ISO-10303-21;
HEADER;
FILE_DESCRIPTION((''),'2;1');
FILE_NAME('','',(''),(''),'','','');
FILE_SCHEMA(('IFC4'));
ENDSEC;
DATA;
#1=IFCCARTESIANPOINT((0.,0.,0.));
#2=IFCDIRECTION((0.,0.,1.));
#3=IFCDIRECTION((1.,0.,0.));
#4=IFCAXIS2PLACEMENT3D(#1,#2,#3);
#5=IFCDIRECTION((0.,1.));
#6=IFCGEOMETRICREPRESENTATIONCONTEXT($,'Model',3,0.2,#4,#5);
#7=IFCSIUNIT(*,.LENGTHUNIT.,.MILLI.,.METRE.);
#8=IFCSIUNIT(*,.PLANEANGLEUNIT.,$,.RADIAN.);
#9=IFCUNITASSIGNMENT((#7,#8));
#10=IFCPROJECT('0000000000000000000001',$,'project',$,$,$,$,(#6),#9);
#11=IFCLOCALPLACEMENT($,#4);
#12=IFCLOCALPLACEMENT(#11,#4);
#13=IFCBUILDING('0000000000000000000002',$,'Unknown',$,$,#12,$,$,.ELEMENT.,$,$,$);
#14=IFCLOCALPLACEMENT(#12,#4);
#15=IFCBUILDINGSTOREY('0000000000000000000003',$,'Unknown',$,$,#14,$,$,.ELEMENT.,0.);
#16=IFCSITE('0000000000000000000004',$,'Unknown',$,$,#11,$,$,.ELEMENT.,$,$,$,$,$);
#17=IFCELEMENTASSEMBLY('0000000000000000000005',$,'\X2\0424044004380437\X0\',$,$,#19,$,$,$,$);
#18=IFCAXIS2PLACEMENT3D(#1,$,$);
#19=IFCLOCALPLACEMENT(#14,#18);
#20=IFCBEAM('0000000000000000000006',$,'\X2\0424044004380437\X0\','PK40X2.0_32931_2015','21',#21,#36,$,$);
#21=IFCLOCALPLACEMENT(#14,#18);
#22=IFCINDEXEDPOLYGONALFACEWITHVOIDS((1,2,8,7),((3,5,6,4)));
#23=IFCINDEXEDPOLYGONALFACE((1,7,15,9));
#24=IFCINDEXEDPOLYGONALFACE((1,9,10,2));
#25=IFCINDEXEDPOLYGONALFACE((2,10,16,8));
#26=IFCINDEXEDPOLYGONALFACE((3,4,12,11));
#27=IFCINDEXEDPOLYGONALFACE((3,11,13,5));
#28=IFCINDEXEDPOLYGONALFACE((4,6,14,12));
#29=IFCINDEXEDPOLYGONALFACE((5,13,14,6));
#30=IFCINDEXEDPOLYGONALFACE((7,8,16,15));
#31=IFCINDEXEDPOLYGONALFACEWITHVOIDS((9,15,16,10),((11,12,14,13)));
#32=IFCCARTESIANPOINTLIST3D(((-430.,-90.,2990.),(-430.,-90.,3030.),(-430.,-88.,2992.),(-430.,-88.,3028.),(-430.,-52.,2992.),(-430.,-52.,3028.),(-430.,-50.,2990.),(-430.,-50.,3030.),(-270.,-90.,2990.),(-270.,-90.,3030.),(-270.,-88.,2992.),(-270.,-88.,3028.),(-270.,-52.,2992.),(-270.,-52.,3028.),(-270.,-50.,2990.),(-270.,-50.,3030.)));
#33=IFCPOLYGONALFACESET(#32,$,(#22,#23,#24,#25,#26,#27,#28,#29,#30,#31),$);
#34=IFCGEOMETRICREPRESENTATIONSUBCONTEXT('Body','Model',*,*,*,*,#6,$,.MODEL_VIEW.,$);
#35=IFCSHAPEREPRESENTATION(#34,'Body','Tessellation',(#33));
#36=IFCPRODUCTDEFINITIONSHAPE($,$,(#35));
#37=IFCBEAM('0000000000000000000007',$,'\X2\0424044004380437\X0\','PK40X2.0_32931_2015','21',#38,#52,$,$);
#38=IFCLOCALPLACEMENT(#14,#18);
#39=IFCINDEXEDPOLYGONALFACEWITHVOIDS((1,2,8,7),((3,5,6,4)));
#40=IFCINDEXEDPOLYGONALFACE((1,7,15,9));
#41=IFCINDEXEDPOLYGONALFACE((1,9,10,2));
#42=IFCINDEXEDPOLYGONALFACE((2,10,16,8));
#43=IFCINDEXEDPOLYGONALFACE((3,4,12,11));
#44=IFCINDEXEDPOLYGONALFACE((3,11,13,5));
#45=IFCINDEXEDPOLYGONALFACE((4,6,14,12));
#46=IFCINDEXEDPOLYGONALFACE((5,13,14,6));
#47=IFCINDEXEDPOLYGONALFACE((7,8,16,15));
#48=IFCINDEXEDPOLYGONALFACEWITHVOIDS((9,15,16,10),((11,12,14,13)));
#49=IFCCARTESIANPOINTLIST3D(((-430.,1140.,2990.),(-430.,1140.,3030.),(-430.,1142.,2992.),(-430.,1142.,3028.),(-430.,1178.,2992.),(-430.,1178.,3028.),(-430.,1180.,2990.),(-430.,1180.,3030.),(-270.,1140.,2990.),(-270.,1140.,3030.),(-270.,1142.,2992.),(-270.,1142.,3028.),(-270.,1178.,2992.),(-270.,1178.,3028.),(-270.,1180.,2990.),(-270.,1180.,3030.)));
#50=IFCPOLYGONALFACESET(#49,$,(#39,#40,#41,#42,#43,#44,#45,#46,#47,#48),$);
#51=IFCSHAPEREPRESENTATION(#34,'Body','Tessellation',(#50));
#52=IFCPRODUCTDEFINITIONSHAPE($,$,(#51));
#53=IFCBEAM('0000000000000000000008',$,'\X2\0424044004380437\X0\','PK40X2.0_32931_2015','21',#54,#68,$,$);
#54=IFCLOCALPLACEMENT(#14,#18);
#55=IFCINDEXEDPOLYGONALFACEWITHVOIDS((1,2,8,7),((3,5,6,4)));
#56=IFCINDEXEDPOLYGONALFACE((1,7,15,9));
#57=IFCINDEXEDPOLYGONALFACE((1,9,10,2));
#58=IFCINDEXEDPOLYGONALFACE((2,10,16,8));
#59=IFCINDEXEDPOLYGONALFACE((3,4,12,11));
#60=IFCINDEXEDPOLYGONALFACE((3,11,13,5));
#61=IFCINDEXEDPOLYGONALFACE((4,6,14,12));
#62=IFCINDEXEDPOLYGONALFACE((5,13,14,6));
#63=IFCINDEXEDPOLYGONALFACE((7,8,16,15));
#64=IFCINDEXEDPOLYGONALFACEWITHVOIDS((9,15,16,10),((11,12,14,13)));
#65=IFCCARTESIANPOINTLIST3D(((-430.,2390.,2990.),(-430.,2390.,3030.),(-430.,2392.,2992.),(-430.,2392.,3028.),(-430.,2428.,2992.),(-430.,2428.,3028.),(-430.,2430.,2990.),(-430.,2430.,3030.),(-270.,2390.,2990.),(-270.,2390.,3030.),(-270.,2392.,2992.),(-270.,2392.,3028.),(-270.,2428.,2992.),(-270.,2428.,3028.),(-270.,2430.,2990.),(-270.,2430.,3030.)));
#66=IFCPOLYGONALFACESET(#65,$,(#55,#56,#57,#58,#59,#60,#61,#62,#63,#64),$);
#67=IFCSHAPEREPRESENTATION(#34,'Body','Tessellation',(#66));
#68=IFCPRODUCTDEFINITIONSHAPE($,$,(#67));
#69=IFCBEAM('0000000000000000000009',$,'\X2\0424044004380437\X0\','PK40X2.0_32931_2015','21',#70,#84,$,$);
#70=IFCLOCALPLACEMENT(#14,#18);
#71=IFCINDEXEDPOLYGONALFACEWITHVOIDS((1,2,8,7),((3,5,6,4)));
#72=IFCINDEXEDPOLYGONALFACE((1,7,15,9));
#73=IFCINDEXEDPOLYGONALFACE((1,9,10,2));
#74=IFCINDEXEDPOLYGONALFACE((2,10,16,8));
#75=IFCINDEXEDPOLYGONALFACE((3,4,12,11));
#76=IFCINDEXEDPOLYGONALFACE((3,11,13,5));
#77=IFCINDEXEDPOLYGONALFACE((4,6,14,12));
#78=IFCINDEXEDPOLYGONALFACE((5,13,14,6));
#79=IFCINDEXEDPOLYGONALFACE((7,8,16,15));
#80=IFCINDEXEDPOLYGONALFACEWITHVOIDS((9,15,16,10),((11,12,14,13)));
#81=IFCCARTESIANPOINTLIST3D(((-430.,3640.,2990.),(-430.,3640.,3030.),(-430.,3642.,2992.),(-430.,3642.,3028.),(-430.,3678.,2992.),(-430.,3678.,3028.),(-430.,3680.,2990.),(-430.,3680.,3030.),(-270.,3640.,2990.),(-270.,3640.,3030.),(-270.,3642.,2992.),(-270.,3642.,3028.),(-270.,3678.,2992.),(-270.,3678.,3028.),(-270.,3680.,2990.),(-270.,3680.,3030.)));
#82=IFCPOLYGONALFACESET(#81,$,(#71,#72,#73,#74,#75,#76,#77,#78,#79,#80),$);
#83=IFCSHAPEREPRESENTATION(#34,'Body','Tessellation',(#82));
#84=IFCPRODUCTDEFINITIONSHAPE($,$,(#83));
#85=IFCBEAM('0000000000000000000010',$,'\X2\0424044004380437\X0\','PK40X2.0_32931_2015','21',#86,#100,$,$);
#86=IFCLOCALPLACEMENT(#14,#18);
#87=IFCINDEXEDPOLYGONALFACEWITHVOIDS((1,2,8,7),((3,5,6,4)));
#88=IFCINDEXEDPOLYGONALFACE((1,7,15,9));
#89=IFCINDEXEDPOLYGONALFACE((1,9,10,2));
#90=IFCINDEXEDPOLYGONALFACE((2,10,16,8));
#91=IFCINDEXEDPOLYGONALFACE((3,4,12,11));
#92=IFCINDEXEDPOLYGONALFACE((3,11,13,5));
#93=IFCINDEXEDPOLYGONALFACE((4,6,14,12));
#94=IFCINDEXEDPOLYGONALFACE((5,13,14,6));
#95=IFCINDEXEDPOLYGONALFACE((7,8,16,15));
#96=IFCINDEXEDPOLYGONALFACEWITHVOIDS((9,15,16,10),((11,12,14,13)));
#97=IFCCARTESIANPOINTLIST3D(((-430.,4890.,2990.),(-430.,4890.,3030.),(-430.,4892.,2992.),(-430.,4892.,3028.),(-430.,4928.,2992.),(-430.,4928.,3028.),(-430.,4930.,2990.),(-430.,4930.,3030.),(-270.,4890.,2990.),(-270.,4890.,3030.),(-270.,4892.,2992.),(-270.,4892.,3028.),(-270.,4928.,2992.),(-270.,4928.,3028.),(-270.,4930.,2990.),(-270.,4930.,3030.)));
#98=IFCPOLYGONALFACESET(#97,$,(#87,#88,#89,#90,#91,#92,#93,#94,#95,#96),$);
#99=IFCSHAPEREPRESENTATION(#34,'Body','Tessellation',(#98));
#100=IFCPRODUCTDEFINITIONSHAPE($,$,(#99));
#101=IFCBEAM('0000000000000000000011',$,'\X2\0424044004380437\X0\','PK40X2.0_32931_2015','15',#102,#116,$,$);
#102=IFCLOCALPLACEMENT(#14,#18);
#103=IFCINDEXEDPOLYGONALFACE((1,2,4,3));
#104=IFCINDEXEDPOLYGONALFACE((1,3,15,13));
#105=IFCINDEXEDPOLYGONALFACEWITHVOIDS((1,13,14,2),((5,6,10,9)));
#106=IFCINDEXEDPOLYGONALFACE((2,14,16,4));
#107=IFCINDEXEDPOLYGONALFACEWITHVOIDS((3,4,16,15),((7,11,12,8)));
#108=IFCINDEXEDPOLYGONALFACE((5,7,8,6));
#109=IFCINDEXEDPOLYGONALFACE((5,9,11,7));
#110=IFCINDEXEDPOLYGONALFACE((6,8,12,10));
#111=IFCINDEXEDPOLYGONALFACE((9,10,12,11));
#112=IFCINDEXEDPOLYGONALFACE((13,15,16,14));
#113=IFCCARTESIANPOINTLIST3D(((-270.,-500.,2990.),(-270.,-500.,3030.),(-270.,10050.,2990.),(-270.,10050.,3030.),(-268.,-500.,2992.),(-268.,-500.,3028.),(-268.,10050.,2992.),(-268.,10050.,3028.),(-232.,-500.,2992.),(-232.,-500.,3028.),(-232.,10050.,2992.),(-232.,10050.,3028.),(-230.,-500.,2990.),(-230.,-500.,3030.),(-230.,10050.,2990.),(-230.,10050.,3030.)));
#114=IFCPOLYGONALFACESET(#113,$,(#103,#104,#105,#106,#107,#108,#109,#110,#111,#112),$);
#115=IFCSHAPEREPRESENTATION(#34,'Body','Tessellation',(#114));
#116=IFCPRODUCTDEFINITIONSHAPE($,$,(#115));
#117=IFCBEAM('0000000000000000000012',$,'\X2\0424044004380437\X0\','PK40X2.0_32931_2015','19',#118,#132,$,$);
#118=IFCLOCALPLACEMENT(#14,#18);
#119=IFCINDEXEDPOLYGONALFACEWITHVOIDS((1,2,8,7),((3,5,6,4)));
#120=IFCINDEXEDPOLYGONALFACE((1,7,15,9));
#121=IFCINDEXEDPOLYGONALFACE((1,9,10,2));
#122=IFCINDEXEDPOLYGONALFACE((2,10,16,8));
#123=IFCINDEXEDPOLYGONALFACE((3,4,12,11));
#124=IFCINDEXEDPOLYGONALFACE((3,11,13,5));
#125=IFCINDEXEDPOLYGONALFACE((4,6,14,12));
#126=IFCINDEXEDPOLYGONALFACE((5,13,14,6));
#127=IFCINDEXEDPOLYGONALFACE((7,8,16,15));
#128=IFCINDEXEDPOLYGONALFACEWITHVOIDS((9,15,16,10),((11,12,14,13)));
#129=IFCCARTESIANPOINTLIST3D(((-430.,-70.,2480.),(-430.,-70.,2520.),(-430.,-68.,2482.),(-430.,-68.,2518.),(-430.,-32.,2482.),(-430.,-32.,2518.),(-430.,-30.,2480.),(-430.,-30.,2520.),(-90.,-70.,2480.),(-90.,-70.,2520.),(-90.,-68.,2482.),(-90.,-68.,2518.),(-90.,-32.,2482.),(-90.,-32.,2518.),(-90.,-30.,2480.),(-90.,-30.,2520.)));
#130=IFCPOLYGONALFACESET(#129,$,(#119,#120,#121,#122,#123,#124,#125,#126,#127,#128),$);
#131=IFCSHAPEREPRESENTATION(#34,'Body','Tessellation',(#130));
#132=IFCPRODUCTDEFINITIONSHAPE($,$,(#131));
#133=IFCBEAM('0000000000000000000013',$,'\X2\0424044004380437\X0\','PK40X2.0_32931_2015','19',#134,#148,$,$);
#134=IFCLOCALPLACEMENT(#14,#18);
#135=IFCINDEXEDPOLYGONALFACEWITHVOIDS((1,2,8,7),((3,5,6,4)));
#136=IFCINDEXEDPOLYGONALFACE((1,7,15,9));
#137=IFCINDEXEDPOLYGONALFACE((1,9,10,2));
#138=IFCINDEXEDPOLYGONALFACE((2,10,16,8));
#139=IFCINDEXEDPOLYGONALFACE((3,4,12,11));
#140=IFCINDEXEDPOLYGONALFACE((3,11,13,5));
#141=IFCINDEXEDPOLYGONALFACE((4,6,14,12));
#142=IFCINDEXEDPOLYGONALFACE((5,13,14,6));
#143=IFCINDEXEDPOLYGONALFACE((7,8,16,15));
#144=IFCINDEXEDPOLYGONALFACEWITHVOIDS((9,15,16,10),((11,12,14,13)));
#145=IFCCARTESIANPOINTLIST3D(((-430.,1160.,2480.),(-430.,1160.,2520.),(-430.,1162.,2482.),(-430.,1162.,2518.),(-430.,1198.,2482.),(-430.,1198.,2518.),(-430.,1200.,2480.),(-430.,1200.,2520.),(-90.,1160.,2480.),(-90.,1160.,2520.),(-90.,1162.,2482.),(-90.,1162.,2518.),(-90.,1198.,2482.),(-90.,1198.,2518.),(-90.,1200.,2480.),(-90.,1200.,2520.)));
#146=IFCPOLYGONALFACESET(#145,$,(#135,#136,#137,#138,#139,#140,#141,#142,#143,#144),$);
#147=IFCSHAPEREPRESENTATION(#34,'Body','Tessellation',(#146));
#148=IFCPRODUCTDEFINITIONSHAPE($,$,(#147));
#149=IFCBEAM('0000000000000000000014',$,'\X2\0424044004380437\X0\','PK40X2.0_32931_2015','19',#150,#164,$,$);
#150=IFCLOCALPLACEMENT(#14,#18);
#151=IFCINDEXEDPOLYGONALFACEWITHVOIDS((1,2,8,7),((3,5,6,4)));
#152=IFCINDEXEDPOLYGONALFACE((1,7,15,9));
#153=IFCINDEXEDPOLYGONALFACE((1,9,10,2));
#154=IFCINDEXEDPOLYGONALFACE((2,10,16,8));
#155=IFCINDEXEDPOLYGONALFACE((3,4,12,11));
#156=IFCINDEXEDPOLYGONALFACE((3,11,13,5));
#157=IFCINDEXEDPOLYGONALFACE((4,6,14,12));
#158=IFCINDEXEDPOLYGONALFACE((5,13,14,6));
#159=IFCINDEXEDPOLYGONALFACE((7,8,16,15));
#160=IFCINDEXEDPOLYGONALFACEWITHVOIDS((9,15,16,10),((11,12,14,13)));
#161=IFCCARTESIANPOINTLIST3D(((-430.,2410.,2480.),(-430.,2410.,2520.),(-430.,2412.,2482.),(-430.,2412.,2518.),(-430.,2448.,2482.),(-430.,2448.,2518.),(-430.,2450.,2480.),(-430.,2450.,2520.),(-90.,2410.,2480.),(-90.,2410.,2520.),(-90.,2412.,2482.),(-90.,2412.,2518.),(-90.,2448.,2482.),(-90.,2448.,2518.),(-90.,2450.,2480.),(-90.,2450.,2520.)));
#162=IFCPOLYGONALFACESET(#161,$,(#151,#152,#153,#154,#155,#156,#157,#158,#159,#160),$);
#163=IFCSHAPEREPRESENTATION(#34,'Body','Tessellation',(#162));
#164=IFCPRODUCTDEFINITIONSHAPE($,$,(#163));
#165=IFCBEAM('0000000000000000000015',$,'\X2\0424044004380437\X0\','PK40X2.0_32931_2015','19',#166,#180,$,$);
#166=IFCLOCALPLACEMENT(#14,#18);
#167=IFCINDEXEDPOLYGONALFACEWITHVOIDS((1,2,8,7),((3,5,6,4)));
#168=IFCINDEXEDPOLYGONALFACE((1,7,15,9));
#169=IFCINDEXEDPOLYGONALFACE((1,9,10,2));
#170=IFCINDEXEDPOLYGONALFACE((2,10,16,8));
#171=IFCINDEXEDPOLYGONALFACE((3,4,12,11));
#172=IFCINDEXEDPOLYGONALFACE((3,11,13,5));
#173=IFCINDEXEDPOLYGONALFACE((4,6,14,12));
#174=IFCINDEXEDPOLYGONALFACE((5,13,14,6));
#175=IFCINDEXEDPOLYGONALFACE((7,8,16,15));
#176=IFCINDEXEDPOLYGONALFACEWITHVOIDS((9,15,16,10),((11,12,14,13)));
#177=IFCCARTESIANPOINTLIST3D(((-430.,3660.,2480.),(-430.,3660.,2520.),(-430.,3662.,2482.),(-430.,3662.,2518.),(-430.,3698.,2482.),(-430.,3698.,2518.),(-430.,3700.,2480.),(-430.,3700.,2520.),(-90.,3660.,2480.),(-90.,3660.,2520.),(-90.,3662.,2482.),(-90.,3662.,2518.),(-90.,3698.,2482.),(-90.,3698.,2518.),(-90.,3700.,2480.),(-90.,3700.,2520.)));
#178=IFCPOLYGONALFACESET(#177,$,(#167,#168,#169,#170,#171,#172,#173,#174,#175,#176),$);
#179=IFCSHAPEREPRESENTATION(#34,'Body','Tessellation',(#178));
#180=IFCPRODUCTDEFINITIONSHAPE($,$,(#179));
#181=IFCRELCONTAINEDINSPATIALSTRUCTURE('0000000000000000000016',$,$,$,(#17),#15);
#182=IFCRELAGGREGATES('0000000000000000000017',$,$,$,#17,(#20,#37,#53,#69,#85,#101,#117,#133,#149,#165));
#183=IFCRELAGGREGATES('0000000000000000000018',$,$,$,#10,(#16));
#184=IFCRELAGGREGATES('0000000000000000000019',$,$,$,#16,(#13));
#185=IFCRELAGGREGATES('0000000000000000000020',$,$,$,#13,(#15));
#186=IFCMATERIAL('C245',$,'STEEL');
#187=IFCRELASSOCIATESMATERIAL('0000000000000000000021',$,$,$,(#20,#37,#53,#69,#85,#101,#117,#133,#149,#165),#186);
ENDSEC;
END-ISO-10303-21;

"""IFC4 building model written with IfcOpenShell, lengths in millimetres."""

from ifc_helpers import new_model, si_unit, direction, frame, origin_with_axes, place, context, subcontext, project, spatial, line, indexed_curve, outline, extrude, material, element, aggregate, save


model = new_model("IFC4")

# Units and contexts
model_context = context("Model", 3, precision=0.2, world=origin_with_axes(), true_north=direction((0.0, 1.0)))
body_context = subcontext(model_context, "Body", "Model", "MODEL_VIEW")
ifc_project = project(units=[si_unit("LENGTHUNIT", "METRE", prefix="MILLI"), si_unit("PLANEANGLEUNIT", "RADIAN")], contexts=[model_context])

# Site, building, storey
site_placement = place(None, origin_with_axes())
site = spatial("IfcSite", under=ifc_project, at=site_placement, Name="Unknown", CompositionType="ELEMENT")
building_placement = place(site_placement, origin_with_axes())
building = spatial("IfcBuilding", under=site, at=building_placement, Name="Unknown", CompositionType="ELEMENT")
storey_placement = place(building_placement, origin_with_axes())
storey = spatial("IfcBuildingStorey", under=building, at=storey_placement, Name="Unknown", CompositionType="ELEMENT", Elevation=0.0)

# Element assembly
assembly_1_placement = place(storey_placement, frame((-450.0, -500.0, 3010.0), z_axis=(1.0, 0.0, 0.0), x_axis=(0.0, 1.0, 0.0)))
assembly_1 = element("IfcElementAssembly", 1, at=assembly_1_placement, inside=storey, Name="Фриз")
ifc_material = material(Name="C245", Category="STEEL")

# Beams
beam_1_placement = place(assembly_1_placement, frame((430.0, 0.0, 20.0), z_axis=(-1.0, 0.0, 0.0), x_axis=(0.0, 0.0, 1.0)))
beam_1 = element("IfcBeam", 2, at=beam_1_placement, material=ifc_material, Name="Фриз", Description="PK40X2.0_32931_2015", ObjectType="21", context=body_context, shape_type="SolidModel", body=[
    extrude(outline(indexed_curve([(-20.0, -20.0), (20.0, -20.0), (20.0, 20.0), (-20.0, 20.0)], segments=[line(1, 2, 3, 4, 1)]), holes=[indexed_curve([(-18.0, -18.0), (-18.0, 18.0), (18.0, 18.0), (18.0, -18.0)], segments=[line(1, 2, 3, 4, 1)])]), frame((0.0, 0.0, 0.0), z_axis=(-1.0, 0.0, 0.0), x_axis=(0.0, 0.0, 1.0)), (0.0, 0.0, -1.0), 160.0),
])
beam_2_placement = place(assembly_1_placement, frame((1660.0, 0.0, 20.0), z_axis=(-1.0, 0.0, 0.0), x_axis=(0.0, 0.0, 1.0)))
beam_2 = element("IfcBeam", 3, at=beam_2_placement, material=ifc_material, Name="Фриз", Description="PK40X2.0_32931_2015", ObjectType="21", context=body_context, shape_type="SolidModel", body=[
    extrude(outline(indexed_curve([(-20.0, -20.0), (20.0, -20.0), (20.0, 20.0), (-20.0, 20.0)], segments=[line(1, 2, 3, 4, 1)]), holes=[indexed_curve([(-18.0, -18.0), (-18.0, 18.0), (18.0, 18.0), (18.0, -18.0)], segments=[line(1, 2, 3, 4, 1)])]), frame((0.0, 0.0, 0.0), z_axis=(-1.0, 0.0, 0.0), x_axis=(0.0, 0.0, 1.0)), (0.0, 0.0, -1.0), 160.0),
])
beam_3_placement = place(assembly_1_placement, frame((2910.0, 0.0, 20.0), z_axis=(-1.0, 0.0, 0.0), x_axis=(0.0, 0.0, 1.0)))
beam_3 = element("IfcBeam", 4, at=beam_3_placement, material=ifc_material, Name="Фриз", Description="PK40X2.0_32931_2015", ObjectType="21", context=body_context, shape_type="SolidModel", body=[
    extrude(outline(indexed_curve([(-20.0, -20.0), (20.0, -20.0), (20.0, 20.0), (-20.0, 20.0)], segments=[line(1, 2, 3, 4, 1)]), holes=[indexed_curve([(-18.0, -18.0), (-18.0, 18.0), (18.0, 18.0), (18.0, -18.0)], segments=[line(1, 2, 3, 4, 1)])]), frame((0.0, 0.0, 0.0), z_axis=(-1.0, 0.0, 0.0), x_axis=(0.0, 0.0, 1.0)), (0.0, 0.0, -1.0), 160.0),
])
beam_4_placement = place(assembly_1_placement, frame((4160.0, 0.0, 20.0), z_axis=(-1.0, 0.0, 0.0), x_axis=(0.0, 0.0, 1.0)))
beam_4 = element("IfcBeam", 5, at=beam_4_placement, material=ifc_material, Name="Фриз", Description="PK40X2.0_32931_2015", ObjectType="21", context=body_context, shape_type="SolidModel", body=[
    extrude(outline(indexed_curve([(-20.0, -20.0), (20.0, -20.0), (20.0, 20.0), (-20.0, 20.0)], segments=[line(1, 2, 3, 4, 1)]), holes=[indexed_curve([(-18.0, -18.0), (-18.0, 18.0), (18.0, 18.0), (18.0, -18.0)], segments=[line(1, 2, 3, 4, 1)])]), frame((0.0, 0.0, 0.0), z_axis=(-1.0, 0.0, 0.0), x_axis=(0.0, 0.0, 1.0)), (0.0, 0.0, -1.0), 160.0),
])
beam_5_placement = place(assembly_1_placement, frame((5410.0, 0.0, 20.0), z_axis=(-1.0, 0.0, 0.0), x_axis=(0.0, 0.0, 1.0)))
beam_5 = element("IfcBeam", 6, at=beam_5_placement, material=ifc_material, Name="Фриз", Description="PK40X2.0_32931_2015", ObjectType="21", context=body_context, shape_type="SolidModel", body=[
    extrude(outline(indexed_curve([(-20.0, -20.0), (20.0, -20.0), (20.0, 20.0), (-20.0, 20.0)], segments=[line(1, 2, 3, 4, 1)]), holes=[indexed_curve([(-18.0, -18.0), (-18.0, 18.0), (18.0, 18.0), (18.0, -18.0)], segments=[line(1, 2, 3, 4, 1)])]), frame((0.0, 0.0, 0.0), z_axis=(-1.0, 0.0, 0.0), x_axis=(0.0, 0.0, 1.0)), (0.0, 0.0, -1.0), 160.0),
])
beam_6_placement = place(assembly_1_placement, frame((0.0, 0.0, 200.0), z_axis=(0.0, 0.0, 1.0), x_axis=(1.0, 0.0, 0.0)))
beam_6 = element("IfcBeam", 7, at=beam_6_placement, material=ifc_material, Name="Фриз", Description="PK40X2.0_32931_2015", ObjectType="15", context=body_context, shape_type="SolidModel", body=[
    extrude(outline(indexed_curve([(-20.0, -20.0), (20.0, -20.0), (20.0, 20.0), (-20.0, 20.0)], segments=[line(1, 2, 3, 4, 1)]), holes=[indexed_curve([(-18.0, -18.0), (-18.0, 18.0), (18.0, 18.0), (18.0, -18.0)], segments=[line(1, 2, 3, 4, 1)])]), frame((0.0, 0.0, 0.0), z_axis=(-1.0, 0.0, 0.0), x_axis=(0.0, 0.0, 1.0)), (0.0, 0.0, -1.0), 10550.0),
])
beam_7_placement = place(assembly_1_placement, frame((450.0, -510.0, 20.0), z_axis=(-1.0, 0.0, 0.0), x_axis=(0.0, 0.0, 1.0)))
beam_7 = element("IfcBeam", 8, at=beam_7_placement, material=ifc_material, Name="Фриз", Description="PK40X2.0_32931_2015", ObjectType="19", context=body_context, shape_type="SolidModel", body=[
    extrude(outline(indexed_curve([(-20.0, -20.0), (20.0, -20.0), (20.0, 20.0), (-20.0, 20.0)], segments=[line(1, 2, 3, 4, 1)]), holes=[indexed_curve([(-18.0, -18.0), (-18.0, 18.0), (18.0, 18.0), (18.0, -18.0)], segments=[line(1, 2, 3, 4, 1)])]), frame((0.0, 0.0, 0.0), z_axis=(-1.0, 0.0, 0.0), x_axis=(0.0, 0.0, 1.0)), (0.0, 0.0, -1.0), 340.0),
])
beam_8_placement = place(assembly_1_placement, frame((1680.0, -510.0, 20.0), z_axis=(-1.0, 0.0, 0.0), x_axis=(0.0, 0.0, 1.0)))
beam_8 = element("IfcBeam", 9, at=beam_8_placement, material=ifc_material, Name="Фриз", Description="PK40X2.0_32931_2015", ObjectType="19", context=body_context, shape_type="SolidModel", body=[
    extrude(outline(indexed_curve([(-20.0, -20.0), (20.0, -20.0), (20.0, 20.0), (-20.0, 20.0)], segments=[line(1, 2, 3, 4, 1)]), holes=[indexed_curve([(-18.0, -18.0), (-18.0, 18.0), (18.0, 18.0), (18.0, -18.0)], segments=[line(1, 2, 3, 4, 1)])]), frame((0.0, 0.0, 0.0), z_axis=(-1.0, 0.0, 0.0), x_axis=(0.0, 0.0, 1.0)), (0.0, 0.0, -1.0), 340.0),
])
beam_9_placement = place(assembly_1_placement, frame((2930.0, -510.0, 20.0), z_axis=(-1.0, 0.0, 0.0), x_axis=(0.0, 0.0, 1.0)))
beam_9 = element("IfcBeam", 10, at=beam_9_placement, material=ifc_material, Name="Фриз", Description="PK40X2.0_32931_2015", ObjectType="19", context=body_context, shape_type="SolidModel", body=[
    extrude(outline(indexed_curve([(-20.0, -20.0), (20.0, -20.0), (20.0, 20.0), (-20.0, 20.0)], segments=[line(1, 2, 3, 4, 1)]), holes=[indexed_curve([(-18.0, -18.0), (-18.0, 18.0), (18.0, 18.0), (18.0, -18.0)], segments=[line(1, 2, 3, 4, 1)])]), frame((0.0, 0.0, 0.0), z_axis=(-1.0, 0.0, 0.0), x_axis=(0.0, 0.0, 1.0)), (0.0, 0.0, -1.0), 340.0),
])
beam_10_placement = place(assembly_1_placement, frame((4180.0, -510.0, 20.0), z_axis=(-1.0, 0.0, 0.0), x_axis=(0.0, 0.0, 1.0)))
beam_10 = element("IfcBeam", 11, at=beam_10_placement, material=ifc_material, Name="Фриз", Description="PK40X2.0_32931_2015", ObjectType="19", context=body_context, shape_type="SolidModel", body=[
    extrude(outline(indexed_curve([(-20.0, -20.0), (20.0, -20.0), (20.0, 20.0), (-20.0, 20.0)], segments=[line(1, 2, 3, 4, 1)]), holes=[indexed_curve([(-18.0, -18.0), (-18.0, 18.0), (18.0, 18.0), (18.0, -18.0)], segments=[line(1, 2, 3, 4, 1)])]), frame((0.0, 0.0, 0.0), z_axis=(-1.0, 0.0, 0.0), x_axis=(0.0, 0.0, 1.0)), (0.0, 0.0, -1.0), 340.0),
])
aggregate(assembly_1, [beam_1, beam_2, beam_3, beam_4, beam_5, beam_6, beam_7, beam_8, beam_9, beam_10])

save(model, "model.ifc")
